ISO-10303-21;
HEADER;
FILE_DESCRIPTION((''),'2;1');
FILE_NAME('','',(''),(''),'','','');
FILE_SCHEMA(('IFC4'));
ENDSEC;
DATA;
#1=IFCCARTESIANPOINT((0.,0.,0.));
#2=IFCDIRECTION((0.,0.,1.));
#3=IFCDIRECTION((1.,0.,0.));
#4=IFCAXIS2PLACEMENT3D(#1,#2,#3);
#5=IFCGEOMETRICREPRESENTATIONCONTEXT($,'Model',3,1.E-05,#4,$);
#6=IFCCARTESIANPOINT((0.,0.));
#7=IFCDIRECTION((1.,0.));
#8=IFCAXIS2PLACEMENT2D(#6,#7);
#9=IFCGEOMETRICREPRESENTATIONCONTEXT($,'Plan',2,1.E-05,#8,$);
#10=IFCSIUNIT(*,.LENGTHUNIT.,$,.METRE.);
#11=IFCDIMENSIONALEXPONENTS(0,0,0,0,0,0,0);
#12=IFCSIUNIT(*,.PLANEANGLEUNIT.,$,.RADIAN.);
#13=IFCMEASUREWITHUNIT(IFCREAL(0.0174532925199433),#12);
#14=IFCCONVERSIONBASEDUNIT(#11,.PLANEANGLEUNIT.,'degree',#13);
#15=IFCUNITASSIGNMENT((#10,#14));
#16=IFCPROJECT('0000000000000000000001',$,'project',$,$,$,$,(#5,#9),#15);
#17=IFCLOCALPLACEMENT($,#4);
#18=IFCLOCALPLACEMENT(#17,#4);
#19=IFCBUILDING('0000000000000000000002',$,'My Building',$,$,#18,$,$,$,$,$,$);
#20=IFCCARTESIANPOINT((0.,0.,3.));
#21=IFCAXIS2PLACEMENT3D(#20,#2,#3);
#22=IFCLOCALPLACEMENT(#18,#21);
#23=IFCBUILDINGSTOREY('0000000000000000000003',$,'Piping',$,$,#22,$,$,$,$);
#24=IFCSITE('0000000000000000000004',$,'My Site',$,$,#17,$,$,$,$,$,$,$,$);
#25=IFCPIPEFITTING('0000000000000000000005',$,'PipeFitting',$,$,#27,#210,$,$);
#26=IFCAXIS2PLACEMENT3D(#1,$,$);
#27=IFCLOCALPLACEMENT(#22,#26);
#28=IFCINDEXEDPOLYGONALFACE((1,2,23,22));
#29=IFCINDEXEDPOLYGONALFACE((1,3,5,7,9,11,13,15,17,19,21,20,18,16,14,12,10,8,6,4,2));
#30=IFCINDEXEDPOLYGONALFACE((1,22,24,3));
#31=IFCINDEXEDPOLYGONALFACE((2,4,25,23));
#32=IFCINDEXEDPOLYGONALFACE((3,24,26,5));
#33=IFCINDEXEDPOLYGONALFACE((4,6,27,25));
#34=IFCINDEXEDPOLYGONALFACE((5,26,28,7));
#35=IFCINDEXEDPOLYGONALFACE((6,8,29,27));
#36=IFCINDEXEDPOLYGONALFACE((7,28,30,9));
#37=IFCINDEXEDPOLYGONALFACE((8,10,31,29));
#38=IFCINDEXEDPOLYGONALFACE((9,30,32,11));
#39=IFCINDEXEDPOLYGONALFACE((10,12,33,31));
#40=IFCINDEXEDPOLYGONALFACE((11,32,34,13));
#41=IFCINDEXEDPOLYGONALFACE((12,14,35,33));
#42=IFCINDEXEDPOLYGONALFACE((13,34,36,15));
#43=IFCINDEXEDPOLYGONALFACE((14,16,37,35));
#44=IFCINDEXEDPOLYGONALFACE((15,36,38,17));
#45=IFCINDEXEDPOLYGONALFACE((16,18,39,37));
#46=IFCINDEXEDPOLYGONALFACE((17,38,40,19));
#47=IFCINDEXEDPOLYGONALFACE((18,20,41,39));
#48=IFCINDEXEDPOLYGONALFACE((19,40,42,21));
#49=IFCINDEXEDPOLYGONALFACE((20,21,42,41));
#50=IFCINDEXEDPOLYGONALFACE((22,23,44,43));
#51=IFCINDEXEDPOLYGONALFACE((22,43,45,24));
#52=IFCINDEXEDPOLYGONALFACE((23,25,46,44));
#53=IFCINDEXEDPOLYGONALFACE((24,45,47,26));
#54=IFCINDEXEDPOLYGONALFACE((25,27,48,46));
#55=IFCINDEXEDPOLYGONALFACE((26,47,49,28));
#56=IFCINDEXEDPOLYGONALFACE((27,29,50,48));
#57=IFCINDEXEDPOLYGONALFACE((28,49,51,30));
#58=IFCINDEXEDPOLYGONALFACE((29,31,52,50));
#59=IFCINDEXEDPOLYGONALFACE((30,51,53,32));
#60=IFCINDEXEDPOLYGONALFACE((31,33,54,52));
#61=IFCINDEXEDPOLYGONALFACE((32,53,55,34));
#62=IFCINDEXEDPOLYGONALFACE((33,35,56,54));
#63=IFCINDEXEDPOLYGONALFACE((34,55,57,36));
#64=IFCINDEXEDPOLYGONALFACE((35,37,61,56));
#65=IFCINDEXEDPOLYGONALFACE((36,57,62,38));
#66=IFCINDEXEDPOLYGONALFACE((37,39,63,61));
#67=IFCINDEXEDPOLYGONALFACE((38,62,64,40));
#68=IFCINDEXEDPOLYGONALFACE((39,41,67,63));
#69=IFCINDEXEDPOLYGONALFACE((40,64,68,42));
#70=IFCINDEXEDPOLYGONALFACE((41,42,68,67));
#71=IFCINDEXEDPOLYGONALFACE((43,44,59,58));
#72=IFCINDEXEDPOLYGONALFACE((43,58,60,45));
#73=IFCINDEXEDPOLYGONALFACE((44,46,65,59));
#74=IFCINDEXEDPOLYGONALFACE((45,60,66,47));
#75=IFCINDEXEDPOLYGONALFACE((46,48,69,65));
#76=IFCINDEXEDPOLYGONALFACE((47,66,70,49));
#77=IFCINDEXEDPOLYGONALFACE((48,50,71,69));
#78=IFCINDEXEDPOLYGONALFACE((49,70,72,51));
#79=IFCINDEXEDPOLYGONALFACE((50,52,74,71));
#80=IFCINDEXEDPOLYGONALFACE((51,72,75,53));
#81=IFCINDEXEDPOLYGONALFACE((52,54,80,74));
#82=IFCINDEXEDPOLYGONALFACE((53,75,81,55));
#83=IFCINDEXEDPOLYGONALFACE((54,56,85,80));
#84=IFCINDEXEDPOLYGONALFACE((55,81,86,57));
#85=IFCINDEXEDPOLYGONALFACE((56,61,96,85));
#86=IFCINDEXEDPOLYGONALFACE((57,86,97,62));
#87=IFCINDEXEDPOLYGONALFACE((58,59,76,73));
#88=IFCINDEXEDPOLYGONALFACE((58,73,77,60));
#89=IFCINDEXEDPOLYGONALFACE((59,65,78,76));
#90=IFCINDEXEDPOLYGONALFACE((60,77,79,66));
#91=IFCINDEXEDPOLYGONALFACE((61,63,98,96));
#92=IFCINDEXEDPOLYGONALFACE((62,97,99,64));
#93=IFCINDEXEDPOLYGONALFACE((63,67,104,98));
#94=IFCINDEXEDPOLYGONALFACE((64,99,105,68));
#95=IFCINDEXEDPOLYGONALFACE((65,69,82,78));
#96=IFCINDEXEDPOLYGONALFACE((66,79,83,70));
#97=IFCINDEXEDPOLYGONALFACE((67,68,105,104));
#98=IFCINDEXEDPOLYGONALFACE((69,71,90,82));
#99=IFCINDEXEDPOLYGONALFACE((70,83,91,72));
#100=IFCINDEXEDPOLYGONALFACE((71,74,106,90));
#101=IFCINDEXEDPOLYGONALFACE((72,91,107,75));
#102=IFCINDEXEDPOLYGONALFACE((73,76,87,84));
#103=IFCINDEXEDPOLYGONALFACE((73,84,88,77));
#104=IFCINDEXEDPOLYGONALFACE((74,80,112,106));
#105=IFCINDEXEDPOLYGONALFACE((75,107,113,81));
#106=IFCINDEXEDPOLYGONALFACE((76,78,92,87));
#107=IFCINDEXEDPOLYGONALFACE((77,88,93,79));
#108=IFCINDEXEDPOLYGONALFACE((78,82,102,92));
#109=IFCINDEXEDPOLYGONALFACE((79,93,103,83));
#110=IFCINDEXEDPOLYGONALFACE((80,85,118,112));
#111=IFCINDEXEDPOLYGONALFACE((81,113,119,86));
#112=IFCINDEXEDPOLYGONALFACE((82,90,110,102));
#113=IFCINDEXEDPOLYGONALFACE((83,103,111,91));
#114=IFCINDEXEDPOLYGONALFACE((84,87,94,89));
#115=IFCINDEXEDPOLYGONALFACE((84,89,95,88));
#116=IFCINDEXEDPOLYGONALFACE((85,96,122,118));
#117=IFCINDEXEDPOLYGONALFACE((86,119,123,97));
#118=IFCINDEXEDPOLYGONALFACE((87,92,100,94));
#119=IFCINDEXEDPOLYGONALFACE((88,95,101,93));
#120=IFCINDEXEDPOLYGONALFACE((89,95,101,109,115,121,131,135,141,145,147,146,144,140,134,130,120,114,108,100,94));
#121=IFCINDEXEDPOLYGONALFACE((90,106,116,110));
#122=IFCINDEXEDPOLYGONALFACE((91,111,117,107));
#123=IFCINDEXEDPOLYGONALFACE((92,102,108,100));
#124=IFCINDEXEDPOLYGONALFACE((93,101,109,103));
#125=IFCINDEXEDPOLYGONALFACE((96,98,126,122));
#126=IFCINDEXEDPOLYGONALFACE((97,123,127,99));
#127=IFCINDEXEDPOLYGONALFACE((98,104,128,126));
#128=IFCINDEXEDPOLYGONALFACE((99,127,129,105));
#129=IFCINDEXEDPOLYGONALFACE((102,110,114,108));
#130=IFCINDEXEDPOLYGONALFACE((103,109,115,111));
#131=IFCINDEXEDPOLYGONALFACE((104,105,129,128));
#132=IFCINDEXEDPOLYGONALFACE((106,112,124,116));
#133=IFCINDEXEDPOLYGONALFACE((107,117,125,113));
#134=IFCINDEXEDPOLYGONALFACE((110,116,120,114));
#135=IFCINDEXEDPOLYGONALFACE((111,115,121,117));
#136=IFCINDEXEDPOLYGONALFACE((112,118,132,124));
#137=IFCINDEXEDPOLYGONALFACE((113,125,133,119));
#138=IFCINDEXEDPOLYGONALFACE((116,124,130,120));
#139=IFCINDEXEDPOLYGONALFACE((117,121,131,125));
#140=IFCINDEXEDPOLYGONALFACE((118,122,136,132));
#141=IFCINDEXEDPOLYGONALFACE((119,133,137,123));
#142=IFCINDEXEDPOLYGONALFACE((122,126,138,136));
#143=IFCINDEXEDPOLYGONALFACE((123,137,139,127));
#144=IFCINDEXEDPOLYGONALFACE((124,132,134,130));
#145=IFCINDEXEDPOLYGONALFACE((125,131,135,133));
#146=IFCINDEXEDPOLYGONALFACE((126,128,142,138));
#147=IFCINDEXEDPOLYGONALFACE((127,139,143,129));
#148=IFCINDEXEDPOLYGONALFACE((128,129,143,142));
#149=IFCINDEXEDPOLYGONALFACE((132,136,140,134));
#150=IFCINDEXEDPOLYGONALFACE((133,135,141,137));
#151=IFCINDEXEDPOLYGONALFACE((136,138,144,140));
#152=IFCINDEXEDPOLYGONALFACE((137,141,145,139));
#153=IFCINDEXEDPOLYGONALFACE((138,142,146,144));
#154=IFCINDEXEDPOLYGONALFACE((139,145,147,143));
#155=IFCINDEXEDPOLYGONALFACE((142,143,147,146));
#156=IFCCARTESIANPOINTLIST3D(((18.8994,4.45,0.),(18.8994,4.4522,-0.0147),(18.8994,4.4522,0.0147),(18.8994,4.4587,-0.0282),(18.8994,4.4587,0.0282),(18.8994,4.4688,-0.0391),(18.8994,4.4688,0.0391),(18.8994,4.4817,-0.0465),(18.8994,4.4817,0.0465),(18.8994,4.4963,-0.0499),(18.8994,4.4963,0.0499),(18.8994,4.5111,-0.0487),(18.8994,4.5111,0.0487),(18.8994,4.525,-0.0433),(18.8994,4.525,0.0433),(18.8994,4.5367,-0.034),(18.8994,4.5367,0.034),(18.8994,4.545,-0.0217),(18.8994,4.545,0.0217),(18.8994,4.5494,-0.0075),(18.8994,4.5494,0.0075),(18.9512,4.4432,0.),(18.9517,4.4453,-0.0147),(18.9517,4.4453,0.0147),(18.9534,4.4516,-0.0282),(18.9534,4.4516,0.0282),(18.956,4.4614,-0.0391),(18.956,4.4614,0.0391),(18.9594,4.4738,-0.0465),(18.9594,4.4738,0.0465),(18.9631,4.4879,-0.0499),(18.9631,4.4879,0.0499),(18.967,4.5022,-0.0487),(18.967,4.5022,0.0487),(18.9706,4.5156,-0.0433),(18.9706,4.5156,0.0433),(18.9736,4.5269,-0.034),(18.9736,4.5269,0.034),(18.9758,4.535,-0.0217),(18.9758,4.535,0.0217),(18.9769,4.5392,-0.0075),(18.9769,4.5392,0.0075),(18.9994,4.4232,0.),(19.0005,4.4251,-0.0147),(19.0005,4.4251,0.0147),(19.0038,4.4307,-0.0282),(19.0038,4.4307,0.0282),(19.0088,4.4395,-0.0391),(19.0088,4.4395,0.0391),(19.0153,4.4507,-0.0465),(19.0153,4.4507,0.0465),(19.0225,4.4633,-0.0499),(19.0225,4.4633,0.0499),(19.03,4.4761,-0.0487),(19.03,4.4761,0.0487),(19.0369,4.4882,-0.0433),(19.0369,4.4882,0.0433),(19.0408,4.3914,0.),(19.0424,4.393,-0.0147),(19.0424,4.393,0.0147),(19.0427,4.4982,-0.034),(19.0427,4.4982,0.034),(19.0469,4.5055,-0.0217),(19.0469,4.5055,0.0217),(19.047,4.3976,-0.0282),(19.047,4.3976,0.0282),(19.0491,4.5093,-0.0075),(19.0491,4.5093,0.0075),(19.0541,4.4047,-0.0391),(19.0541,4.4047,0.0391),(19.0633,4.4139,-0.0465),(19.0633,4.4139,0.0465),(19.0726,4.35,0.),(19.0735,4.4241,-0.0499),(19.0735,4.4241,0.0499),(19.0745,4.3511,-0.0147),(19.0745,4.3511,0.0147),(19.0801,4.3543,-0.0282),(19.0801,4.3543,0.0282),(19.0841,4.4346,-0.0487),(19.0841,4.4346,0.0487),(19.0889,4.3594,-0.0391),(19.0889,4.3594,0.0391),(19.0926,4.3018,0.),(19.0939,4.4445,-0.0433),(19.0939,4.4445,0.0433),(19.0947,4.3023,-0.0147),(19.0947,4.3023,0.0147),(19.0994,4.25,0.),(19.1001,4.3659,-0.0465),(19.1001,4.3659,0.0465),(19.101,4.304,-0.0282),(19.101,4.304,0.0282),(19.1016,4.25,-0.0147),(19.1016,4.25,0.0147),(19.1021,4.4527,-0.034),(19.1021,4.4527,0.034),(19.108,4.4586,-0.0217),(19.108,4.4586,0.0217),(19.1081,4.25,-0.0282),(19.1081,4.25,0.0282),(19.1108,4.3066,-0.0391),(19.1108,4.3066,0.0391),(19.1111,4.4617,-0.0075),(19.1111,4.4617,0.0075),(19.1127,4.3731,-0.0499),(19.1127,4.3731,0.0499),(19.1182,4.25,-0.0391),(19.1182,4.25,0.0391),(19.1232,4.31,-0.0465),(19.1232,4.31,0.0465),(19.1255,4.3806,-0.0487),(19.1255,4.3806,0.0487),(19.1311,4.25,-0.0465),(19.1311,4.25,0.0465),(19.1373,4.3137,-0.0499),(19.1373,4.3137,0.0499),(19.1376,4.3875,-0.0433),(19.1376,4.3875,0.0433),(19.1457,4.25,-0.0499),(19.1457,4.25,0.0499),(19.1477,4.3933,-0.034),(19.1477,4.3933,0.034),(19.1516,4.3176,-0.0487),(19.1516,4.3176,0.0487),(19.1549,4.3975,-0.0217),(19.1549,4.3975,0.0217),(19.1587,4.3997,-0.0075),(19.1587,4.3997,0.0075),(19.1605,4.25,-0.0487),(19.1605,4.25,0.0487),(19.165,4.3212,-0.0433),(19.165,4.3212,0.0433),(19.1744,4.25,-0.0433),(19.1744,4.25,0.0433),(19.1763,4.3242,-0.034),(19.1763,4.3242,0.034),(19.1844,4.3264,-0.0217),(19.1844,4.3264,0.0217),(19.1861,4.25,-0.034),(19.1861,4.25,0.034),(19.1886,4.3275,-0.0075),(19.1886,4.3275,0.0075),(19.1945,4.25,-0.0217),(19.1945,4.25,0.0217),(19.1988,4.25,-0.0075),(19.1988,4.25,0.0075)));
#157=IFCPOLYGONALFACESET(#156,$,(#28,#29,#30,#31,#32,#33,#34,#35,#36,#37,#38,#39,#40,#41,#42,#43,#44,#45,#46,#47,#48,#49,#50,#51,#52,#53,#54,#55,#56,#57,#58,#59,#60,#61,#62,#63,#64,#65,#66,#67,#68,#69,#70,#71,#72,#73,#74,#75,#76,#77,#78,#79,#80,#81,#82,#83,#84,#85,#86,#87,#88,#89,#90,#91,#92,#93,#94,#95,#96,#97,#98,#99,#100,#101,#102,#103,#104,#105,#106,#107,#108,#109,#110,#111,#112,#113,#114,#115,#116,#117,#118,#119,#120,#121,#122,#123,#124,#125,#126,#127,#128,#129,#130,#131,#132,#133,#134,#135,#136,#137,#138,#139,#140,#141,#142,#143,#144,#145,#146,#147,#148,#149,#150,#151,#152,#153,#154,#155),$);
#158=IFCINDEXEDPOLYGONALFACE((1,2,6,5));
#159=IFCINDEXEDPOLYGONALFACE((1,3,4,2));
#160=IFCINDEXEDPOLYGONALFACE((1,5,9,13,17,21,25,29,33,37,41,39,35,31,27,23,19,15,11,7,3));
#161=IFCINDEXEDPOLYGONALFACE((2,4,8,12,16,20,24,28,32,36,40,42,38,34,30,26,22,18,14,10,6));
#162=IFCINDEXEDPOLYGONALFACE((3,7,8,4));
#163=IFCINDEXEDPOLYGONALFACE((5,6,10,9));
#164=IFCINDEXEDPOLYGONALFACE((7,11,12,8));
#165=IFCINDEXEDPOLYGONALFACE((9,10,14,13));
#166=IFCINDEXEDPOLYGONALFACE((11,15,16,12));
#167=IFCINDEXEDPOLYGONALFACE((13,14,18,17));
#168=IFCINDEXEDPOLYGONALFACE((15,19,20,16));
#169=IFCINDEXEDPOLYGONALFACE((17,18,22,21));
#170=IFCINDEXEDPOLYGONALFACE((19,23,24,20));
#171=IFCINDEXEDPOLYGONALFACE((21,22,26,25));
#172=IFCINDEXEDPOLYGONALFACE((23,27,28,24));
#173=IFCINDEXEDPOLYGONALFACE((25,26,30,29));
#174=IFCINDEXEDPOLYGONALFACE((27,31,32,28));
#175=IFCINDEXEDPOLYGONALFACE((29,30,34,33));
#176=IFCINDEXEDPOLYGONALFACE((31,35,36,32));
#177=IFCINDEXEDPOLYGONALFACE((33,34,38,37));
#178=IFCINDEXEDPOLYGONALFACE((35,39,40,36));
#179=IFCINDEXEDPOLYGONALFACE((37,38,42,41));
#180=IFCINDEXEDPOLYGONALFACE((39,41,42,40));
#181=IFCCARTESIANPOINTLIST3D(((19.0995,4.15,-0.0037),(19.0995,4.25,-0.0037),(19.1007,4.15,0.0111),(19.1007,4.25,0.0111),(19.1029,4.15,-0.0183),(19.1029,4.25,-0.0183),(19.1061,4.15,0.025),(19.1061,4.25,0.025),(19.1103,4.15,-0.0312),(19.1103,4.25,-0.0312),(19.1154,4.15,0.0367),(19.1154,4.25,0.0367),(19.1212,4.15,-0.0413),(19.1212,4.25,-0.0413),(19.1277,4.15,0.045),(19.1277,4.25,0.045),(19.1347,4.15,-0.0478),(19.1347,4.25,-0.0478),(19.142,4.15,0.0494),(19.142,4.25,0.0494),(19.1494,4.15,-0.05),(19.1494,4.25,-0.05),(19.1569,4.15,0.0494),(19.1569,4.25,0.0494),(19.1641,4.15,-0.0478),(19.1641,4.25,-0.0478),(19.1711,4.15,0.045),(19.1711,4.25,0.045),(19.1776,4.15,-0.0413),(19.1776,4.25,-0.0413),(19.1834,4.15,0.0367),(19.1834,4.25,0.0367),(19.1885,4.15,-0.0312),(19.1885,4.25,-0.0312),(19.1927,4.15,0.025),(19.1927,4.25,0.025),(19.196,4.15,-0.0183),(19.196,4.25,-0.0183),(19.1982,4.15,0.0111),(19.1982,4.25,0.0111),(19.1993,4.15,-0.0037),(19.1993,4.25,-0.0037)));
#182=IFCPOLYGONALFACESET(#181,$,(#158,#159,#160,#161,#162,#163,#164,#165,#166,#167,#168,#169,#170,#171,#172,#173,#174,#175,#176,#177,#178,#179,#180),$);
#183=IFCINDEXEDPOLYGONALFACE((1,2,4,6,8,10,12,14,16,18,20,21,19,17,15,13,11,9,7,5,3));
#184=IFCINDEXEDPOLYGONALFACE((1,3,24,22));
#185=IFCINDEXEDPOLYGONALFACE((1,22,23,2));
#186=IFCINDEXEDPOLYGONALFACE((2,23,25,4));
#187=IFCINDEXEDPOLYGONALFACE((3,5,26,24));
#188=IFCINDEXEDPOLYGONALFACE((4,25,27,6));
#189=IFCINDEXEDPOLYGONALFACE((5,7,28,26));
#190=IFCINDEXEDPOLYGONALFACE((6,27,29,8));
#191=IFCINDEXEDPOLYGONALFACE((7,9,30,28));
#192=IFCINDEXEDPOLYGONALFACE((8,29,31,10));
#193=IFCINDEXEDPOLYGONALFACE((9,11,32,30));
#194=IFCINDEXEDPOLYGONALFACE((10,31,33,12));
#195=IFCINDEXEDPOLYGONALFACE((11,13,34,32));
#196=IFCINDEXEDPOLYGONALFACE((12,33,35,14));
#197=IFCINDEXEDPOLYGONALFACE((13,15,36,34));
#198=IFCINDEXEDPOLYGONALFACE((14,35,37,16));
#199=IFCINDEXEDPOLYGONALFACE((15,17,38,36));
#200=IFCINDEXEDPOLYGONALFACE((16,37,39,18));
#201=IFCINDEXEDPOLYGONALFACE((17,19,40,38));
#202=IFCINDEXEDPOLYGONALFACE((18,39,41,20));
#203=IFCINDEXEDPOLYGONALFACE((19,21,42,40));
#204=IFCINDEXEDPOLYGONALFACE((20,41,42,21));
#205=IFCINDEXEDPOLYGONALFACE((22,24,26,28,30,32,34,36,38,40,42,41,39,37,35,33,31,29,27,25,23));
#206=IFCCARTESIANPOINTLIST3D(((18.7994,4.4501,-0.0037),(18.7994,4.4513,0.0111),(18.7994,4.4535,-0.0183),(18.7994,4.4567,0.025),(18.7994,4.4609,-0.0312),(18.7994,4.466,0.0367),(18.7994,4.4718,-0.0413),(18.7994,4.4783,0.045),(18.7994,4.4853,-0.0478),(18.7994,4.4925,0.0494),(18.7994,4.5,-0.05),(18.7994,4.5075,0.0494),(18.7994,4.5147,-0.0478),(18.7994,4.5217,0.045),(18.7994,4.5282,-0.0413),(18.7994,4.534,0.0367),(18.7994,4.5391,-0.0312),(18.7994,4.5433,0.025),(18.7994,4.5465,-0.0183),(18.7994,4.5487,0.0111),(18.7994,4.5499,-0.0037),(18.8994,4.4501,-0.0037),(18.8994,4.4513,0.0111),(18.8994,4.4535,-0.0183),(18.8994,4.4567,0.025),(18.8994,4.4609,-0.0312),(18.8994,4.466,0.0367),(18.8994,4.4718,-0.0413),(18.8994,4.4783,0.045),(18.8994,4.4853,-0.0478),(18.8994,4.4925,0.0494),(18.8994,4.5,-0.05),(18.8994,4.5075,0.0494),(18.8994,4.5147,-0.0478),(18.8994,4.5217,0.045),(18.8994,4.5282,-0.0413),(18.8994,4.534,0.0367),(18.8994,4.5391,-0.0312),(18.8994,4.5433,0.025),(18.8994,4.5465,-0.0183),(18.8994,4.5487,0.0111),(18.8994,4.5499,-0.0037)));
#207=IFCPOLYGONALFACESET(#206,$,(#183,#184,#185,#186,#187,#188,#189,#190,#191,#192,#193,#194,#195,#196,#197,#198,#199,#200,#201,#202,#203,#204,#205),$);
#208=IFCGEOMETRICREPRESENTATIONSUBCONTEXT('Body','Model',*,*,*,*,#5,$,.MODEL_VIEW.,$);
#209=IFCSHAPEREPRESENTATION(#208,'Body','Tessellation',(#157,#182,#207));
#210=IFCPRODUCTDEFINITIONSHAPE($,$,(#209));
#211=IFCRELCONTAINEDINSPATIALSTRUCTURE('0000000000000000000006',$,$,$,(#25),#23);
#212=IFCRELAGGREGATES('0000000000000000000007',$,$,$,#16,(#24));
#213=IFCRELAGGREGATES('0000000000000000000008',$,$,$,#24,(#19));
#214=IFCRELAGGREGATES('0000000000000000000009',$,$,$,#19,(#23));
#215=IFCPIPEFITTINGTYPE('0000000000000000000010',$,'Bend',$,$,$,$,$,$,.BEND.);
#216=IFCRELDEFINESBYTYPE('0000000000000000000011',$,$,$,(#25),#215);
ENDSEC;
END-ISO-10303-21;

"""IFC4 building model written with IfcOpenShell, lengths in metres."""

from ifc_helpers import new_model, entity, si_unit, converted_unit, frame, origin_with_axes, origin_2d_with_axis, place, context, subcontext, project, spatial, circle, extrude, source, transform, mapped, type_object, type_shapes, element, save


model = new_model("IFC4")

# Units and contexts
model_context = context("Model", 3, precision=1e-05, world=origin_with_axes())
plan_context = context("Plan", 2, precision=1e-05, world=origin_2d_with_axis())
body_context = subcontext(model_context, "Body", "Model", "MODEL_VIEW")
ifc_project = project(units=[si_unit("LENGTHUNIT", "METRE"), converted_unit("PLANEANGLEUNIT", "degree", entity("IfcReal", 0.0174532925199433), si_unit("PLANEANGLEUNIT", "RADIAN"), dimensions=[0, 0, 0, 0, 0, 0, 0])], contexts=[model_context, plan_context])

# Site, building, storey
site_placement = place(None, origin_with_axes())
site = spatial("IfcSite", under=ifc_project, at=site_placement, Name="My Site")
building_placement = place(site_placement, origin_with_axes())
building = spatial("IfcBuilding", under=site, at=building_placement, Name="My Building")
storey_placement = place(building_placement, frame((0.0, 0.0, 3.0), z_axis=(0.0, 0.0, 1.0), x_axis=(1.0, 0.0, 0.0)))
storey = spatial("IfcBuildingStorey", under=building, at=storey_placement, Name="Piping")

# Pipe fitting
pipe_fitting_type = type_object("IfcPipeFittingType", Name="Bend", PredefinedType="BEND")
shared_shape = source(origin_with_axes(), body_context, "Body", "SolidModel", [
    entity("IfcSweptDiskSolid", entity("IfcIndexedPolyCurve", entity("IfcCartesianPointList3D", [[0.0, 0.0, -0.1], [0.0, -0.0732, -0.2768], [0.0, -0.25, -0.35]]), [entity("IfcArcIndex", [1, 2, 3])]), 0.05),
    extrude(circle(Radius=0.05), origin_with_axes(), (0.0, 0.0, -1.0), 0.1),
    extrude(circle(Radius=0.05), frame((0.0, -0.25, -0.35), z_axis=(0.0, -1.0, 0.0), x_axis=(1.0, 0.0, 0.0)), (0.0, 0.0, 1.0), 0.1),
])
type_shapes(pipe_fitting_type, [shared_shape])
for number, where, z_axis, x_axis, name in (
    (1, (19.1494, 4.15, 0.0), (0.0, -1.0, 0.0), (0.0, 0.0, -1.0), "PipeFitting"),
):
    element("IfcPipeFitting", number, at=place(storey_placement, frame(where, z_axis=z_axis, x_axis=x_axis)), inside=storey, type_object=pipe_fitting_type, Name=name, context=body_context, shape_type="MappedRepresentation", body=[
        mapped(shared_shape, transform((0.0, 0.0, 0.0), x_axis=(1.0, 0.0, 0.0), y_axis=(0.0, 1.0, 0.0), z_axis=(0.0, 0.0, 1.0), scale=1.0)),
    ])

save(model, "model.ifc")
